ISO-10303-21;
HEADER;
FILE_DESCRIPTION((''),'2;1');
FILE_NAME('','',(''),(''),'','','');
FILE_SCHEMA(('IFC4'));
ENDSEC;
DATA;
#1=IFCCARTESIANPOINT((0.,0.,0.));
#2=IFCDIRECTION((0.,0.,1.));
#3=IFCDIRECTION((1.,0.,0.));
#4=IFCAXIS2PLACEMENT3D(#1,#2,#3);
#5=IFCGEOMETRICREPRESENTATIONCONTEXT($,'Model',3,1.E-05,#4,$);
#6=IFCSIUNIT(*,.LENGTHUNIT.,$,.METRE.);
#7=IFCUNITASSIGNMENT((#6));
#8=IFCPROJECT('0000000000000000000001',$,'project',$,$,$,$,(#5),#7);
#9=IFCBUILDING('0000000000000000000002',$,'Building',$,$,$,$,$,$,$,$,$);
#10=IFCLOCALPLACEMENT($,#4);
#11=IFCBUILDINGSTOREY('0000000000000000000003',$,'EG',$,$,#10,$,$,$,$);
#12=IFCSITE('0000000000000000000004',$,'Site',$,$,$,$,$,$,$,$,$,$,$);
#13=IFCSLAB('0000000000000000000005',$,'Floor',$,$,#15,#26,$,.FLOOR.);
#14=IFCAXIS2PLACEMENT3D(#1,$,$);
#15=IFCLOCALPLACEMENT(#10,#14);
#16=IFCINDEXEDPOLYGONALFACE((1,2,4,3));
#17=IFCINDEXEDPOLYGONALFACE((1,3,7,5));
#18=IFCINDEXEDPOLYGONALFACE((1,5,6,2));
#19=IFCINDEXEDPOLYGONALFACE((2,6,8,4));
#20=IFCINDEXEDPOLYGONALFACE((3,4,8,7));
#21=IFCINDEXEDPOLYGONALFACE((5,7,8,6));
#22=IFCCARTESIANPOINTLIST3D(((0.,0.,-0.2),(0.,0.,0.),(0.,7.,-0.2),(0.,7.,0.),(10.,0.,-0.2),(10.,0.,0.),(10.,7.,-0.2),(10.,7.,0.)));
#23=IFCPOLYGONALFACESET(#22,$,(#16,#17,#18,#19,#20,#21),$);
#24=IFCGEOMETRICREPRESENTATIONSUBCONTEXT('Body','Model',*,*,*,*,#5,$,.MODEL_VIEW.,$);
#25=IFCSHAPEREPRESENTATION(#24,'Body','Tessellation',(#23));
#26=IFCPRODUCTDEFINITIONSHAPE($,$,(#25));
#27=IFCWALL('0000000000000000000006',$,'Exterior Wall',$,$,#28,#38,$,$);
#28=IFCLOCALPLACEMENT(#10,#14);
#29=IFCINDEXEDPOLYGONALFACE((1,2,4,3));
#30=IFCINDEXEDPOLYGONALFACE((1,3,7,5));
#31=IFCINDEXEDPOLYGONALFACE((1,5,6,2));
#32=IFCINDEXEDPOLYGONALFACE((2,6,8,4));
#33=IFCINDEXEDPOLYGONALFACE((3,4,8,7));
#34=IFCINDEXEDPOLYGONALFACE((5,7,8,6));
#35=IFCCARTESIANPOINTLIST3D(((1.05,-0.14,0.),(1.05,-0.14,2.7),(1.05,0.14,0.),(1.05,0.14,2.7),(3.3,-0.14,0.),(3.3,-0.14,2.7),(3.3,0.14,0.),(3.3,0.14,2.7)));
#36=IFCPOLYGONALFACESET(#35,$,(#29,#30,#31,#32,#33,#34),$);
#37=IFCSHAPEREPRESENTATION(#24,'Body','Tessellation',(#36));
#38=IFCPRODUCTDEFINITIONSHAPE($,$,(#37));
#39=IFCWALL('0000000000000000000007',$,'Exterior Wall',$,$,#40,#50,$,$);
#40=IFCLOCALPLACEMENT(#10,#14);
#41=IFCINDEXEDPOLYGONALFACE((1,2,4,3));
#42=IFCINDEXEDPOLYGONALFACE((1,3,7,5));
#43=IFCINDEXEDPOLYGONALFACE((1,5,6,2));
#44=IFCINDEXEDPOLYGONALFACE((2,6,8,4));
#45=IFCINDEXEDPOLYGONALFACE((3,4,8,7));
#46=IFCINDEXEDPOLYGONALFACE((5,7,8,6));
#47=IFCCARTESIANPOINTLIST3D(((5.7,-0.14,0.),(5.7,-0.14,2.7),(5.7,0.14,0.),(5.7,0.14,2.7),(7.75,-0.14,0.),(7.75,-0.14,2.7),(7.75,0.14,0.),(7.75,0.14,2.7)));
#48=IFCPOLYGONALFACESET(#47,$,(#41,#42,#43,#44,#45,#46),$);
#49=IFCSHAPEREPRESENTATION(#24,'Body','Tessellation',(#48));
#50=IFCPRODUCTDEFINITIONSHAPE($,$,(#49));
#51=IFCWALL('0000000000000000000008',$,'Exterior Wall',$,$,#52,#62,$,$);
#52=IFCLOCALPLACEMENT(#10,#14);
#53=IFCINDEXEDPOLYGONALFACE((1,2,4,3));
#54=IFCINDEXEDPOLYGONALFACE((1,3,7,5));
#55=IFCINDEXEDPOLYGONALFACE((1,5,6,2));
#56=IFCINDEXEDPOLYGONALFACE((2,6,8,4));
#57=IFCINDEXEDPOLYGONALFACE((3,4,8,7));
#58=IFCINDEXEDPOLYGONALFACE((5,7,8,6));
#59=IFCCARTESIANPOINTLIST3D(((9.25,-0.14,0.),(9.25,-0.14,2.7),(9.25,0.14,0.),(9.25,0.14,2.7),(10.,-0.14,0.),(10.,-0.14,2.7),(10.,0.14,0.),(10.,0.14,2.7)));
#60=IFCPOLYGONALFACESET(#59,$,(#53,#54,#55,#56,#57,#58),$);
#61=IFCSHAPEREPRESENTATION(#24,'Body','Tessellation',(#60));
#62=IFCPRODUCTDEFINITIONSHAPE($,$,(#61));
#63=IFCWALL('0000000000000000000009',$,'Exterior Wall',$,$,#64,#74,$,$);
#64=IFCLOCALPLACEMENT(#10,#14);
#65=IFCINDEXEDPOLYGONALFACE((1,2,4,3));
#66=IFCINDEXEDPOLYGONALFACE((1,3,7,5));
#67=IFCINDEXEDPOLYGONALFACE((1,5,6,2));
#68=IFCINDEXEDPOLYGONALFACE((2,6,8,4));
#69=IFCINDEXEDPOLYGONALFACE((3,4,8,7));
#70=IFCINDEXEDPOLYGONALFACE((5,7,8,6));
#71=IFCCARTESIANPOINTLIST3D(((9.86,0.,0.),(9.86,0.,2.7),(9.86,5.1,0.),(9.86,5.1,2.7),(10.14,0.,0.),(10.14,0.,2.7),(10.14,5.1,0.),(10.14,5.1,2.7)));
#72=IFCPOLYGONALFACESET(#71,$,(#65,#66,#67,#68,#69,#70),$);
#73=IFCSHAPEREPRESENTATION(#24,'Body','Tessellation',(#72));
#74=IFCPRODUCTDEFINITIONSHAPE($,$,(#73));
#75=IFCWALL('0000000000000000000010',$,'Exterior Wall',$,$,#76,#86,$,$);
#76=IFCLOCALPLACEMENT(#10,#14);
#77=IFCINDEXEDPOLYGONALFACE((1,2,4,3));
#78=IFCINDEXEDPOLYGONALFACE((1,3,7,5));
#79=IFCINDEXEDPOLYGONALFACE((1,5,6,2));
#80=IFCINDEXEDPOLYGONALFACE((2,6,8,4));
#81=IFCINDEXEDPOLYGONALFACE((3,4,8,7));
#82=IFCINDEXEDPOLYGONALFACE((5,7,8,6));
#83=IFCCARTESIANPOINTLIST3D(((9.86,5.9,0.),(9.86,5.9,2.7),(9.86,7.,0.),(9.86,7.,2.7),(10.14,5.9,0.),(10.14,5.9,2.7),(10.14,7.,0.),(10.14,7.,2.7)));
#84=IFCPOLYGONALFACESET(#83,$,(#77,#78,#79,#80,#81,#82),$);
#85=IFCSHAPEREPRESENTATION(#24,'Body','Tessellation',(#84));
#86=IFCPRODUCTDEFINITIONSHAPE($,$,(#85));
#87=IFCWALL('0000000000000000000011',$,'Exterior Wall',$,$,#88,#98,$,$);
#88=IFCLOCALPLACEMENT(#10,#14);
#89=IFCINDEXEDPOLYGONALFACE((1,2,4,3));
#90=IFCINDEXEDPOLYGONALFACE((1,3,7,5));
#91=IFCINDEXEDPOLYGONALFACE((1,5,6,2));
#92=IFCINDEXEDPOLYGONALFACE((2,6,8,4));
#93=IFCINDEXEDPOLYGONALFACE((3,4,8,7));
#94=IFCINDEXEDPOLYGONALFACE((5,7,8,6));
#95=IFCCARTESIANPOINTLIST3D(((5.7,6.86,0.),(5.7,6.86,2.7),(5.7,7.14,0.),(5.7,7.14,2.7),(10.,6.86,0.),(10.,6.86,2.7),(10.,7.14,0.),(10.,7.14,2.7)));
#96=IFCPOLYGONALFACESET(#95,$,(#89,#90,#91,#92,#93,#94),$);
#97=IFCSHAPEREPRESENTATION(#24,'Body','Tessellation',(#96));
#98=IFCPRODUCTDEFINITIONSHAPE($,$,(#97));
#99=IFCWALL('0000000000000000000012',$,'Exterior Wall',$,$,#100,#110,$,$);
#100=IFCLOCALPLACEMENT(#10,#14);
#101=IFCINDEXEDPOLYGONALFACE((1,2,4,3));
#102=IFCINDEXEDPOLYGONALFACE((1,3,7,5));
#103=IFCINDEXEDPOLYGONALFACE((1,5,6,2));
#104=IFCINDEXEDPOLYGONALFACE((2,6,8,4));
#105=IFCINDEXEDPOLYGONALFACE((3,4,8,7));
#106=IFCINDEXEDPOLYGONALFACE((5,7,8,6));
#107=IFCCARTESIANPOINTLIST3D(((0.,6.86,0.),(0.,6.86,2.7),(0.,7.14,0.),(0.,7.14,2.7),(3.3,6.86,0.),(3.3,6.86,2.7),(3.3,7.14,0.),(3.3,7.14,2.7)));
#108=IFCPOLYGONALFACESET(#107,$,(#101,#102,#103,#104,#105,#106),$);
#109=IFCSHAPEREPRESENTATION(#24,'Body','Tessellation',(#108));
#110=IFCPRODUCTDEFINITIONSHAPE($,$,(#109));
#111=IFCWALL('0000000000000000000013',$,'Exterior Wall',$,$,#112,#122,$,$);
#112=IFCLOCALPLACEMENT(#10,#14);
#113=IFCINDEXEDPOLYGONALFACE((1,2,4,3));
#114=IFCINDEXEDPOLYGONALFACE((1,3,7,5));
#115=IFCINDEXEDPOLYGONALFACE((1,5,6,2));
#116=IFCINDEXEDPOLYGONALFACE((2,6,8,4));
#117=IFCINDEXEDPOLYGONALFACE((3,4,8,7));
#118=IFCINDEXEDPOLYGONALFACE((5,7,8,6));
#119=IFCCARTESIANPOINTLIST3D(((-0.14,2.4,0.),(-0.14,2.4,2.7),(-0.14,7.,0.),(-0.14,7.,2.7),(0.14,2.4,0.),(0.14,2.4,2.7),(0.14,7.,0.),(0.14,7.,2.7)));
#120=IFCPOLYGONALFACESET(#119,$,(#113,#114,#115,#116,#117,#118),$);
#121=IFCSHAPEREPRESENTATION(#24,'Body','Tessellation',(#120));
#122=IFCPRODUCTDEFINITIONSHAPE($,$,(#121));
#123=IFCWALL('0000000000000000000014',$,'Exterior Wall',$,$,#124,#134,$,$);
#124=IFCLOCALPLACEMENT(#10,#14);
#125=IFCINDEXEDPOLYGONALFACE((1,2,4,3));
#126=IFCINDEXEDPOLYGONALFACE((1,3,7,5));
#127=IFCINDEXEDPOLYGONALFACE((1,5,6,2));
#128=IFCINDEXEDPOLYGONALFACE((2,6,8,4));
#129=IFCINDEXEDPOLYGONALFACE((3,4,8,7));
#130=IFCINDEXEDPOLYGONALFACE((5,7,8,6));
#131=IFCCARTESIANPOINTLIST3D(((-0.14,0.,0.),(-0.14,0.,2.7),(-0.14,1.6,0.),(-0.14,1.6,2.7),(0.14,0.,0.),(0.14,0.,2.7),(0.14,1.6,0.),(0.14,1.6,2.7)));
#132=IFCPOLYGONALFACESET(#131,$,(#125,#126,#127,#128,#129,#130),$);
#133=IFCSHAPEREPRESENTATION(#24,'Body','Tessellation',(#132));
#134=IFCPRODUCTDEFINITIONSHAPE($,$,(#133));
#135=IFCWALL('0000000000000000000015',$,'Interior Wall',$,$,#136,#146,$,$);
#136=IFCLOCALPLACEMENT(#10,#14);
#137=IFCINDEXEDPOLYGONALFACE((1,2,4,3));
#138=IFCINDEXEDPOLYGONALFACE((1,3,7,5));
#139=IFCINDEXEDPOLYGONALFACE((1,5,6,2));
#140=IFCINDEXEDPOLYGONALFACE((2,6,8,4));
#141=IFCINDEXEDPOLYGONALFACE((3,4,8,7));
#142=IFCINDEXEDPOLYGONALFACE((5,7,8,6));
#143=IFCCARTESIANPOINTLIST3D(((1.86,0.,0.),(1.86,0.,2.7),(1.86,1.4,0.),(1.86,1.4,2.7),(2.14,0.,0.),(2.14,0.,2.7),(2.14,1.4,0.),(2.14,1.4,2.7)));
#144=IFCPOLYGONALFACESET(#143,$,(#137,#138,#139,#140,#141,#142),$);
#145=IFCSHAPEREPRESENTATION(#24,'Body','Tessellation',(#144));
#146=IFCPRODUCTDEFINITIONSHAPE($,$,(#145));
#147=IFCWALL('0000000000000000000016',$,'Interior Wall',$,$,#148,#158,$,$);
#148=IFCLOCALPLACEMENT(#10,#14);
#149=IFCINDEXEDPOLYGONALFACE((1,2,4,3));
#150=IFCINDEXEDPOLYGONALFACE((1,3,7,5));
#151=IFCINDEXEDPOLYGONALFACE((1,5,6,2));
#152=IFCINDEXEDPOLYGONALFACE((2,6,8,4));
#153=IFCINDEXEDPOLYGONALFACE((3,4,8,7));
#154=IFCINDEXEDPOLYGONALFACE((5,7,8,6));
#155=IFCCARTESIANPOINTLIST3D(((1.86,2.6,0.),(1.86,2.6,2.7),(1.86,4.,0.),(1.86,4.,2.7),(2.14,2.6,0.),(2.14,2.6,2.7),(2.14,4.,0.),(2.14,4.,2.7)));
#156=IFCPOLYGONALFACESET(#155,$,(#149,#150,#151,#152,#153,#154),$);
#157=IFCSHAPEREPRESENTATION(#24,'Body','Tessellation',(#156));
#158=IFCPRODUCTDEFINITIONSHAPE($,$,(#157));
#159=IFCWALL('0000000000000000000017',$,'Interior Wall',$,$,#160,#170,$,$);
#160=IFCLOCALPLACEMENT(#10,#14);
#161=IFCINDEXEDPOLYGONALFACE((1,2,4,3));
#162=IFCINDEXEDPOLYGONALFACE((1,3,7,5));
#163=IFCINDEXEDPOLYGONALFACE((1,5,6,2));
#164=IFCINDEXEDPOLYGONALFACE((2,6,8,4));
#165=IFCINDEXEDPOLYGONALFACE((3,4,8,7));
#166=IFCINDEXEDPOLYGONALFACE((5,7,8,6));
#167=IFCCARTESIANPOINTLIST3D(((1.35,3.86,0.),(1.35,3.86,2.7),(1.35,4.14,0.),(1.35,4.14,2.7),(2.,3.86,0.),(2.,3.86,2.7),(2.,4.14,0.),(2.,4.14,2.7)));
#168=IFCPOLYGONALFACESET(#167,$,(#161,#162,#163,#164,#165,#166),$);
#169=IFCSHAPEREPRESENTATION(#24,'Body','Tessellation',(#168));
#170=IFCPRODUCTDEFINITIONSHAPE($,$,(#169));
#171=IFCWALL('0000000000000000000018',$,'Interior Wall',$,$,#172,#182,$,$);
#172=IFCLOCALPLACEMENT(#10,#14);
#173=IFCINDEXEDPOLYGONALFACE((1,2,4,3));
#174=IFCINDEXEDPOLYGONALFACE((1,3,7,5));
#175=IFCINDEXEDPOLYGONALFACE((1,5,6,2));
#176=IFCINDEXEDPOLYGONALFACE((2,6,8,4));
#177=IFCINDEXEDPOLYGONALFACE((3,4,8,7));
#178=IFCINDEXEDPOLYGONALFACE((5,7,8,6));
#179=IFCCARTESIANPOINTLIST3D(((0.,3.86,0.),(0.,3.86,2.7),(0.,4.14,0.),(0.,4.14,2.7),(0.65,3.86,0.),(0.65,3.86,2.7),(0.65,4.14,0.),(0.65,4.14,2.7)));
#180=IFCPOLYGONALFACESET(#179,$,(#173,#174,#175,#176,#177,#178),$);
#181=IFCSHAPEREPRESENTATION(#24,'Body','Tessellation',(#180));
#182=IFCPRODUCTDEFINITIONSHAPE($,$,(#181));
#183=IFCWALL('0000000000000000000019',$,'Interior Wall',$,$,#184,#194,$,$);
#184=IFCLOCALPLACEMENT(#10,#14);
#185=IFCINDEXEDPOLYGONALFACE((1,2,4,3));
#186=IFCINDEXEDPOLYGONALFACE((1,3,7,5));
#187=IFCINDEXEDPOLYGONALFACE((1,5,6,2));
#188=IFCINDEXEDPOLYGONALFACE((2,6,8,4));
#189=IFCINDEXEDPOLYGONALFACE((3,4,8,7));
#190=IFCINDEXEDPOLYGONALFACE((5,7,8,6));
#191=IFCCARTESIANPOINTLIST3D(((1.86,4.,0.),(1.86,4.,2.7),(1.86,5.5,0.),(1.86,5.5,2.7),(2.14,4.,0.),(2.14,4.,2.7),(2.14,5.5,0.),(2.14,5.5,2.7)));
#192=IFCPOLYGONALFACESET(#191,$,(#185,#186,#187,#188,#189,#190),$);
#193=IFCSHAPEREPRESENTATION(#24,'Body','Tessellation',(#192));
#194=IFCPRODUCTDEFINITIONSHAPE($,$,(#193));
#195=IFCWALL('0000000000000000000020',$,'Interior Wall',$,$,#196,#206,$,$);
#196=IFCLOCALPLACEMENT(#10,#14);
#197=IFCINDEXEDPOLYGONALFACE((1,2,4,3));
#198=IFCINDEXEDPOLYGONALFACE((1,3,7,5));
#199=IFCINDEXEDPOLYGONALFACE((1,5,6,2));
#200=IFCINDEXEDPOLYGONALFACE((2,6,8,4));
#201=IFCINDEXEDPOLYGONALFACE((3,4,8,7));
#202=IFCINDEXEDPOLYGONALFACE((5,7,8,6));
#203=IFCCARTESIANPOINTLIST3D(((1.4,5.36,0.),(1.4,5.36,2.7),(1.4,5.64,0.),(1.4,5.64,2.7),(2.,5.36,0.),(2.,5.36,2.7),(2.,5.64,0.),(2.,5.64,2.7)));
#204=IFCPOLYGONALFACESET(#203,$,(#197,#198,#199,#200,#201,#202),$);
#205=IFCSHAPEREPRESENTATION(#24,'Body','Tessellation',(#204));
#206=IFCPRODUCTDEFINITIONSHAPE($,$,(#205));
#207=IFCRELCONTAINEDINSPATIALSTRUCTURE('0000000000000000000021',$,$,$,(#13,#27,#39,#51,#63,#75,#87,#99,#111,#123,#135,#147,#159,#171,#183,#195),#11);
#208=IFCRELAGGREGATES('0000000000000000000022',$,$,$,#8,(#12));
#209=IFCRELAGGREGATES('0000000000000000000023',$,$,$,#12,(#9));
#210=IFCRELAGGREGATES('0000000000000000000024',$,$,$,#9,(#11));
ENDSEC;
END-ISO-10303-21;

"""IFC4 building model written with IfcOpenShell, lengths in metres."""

from ifc_helpers import new_model, si_unit, frame, origin_with_axes, place, context, subcontext, project, spatial, indexed_curve, outline, extrude, element, save


model = new_model("IFC4")

# Units and contexts
model_context = context("Model", 3, precision=1e-05, world=origin_with_axes())
body_context = subcontext(model_context, "Body", "Model", "MODEL_VIEW")
ifc_project = project(units=[si_unit("LENGTHUNIT", "METRE")], contexts=[model_context])

# Site, building, storey
site = spatial("IfcSite", under=ifc_project, Name="Site")
building = spatial("IfcBuilding", under=site, Name="Building")
storey_placement = place(None, origin_with_axes())
storey = spatial("IfcBuildingStorey", under=building, at=storey_placement, Name="EG")

# Slab
slab_placement = place(storey_placement, frame((0.0, 0.0, -0.2), z_axis=(0.0, 0.0, 1.0), x_axis=(1.0, 0.0, 0.0)))
element("IfcSlab", 1, at=slab_placement, inside=storey, Name="Floor", PredefinedType="FLOOR", context=body_context, shape_type="SweptSolid", body=[
    extrude(outline(indexed_curve([(0.0, 0.0), (10.0, 0.0), (10.0, 7.0), (0.0, 7.0)])), None, (0.0, 0.0, 1.0), 0.2),
])

# Walls
wall_1_placement = place(storey_placement, frame((1.05, 0.0, 0.0), z_axis=(0.0, 0.0, 1.0), x_axis=(1.0, 0.0, 0.0)))
element("IfcWall", 2, at=wall_1_placement, inside=storey, Name="Exterior Wall", context=body_context, shape_type="SweptSolid", body=[
    extrude(outline(indexed_curve([(0.0, 0.0), (0.0, 0.28), (2.25, 0.28), (2.25, 0.0), (0.0, 0.0)], self_intersect=False)), frame((0.0, -0.14, 0.0), z_axis=(0.0, 0.0, 1.0), x_axis=(1.0, 0.0, 0.0)), (0.0, 0.0, 1.0), 2.7),
])
wall_2_placement = place(storey_placement, frame((5.7, 0.0, 0.0), z_axis=(0.0, 0.0, 1.0), x_axis=(1.0, 0.0, 0.0)))
element("IfcWall", 3, at=wall_2_placement, inside=storey, Name="Exterior Wall", context=body_context, shape_type="SweptSolid", body=[
    extrude(outline(indexed_curve([(0.0, 0.0), (0.0, 0.28), (2.05, 0.28), (2.05, 0.0), (0.0, 0.0)], self_intersect=False)), frame((0.0, -0.14, 0.0), z_axis=(0.0, 0.0, 1.0), x_axis=(1.0, 0.0, 0.0)), (0.0, 0.0, 1.0), 2.7),
])
wall_3_placement = place(storey_placement, frame((9.25, 0.0, 0.0), z_axis=(0.0, 0.0, 1.0), x_axis=(1.0, 0.0, 0.0)))
element("IfcWall", 4, at=wall_3_placement, inside=storey, Name="Exterior Wall", context=body_context, shape_type="SweptSolid", body=[
    extrude(outline(indexed_curve([(0.0, 0.0), (0.0, 0.28), (0.75, 0.28), (0.75, 0.0), (0.0, 0.0)], self_intersect=False)), frame((0.0, -0.14, 0.0), z_axis=(0.0, 0.0, 1.0), x_axis=(1.0, 0.0, 0.0)), (0.0, 0.0, 1.0), 2.7),
])
wall_4_placement = place(storey_placement, frame((10.0, 0.0, 0.0), z_axis=(0.0, 0.0, 1.0), x_axis=(0.0, 1.0, 0.0)))
element("IfcWall", 5, at=wall_4_placement, inside=storey, Name="Exterior Wall", context=body_context, shape_type="SweptSolid", body=[
    extrude(outline(indexed_curve([(0.0, 0.0), (0.0, 0.28), (5.1, 0.28), (5.1, 0.0), (0.0, 0.0)], self_intersect=False)), frame((0.0, -0.14, 0.0), z_axis=(0.0, 0.0, 1.0), x_axis=(1.0, 0.0, 0.0)), (0.0, 0.0, 1.0), 2.7),
])
wall_5_placement = place(storey_placement, frame((10.0, 5.9, 0.0), z_axis=(0.0, 0.0, 1.0), x_axis=(0.0, 1.0, 0.0)))
element("IfcWall", 6, at=wall_5_placement, inside=storey, Name="Exterior Wall", context=body_context, shape_type="SweptSolid", body=[
    extrude(outline(indexed_curve([(0.0, 0.0), (0.0, 0.28), (1.1, 0.28), (1.1, 0.0), (0.0, 0.0)], self_intersect=False)), frame((0.0, -0.14, 0.0), z_axis=(0.0, 0.0, 1.0), x_axis=(1.0, 0.0, 0.0)), (0.0, 0.0, 1.0), 2.7),
])
wall_6_placement = place(storey_placement, frame((10.0, 7.0, 0.0), z_axis=(0.0, 0.0, 1.0), x_axis=(-1.0, 0.0, 0.0)))
element("IfcWall", 7, at=wall_6_placement, inside=storey, Name="Exterior Wall", context=body_context, shape_type="SweptSolid", body=[
    extrude(outline(indexed_curve([(0.0, 0.0), (0.0, 0.28), (4.3, 0.28), (4.3, 0.0), (0.0, 0.0)], self_intersect=False)), frame((0.0, -0.14, 0.0), z_axis=(0.0, 0.0, 1.0), x_axis=(1.0, 0.0, 0.0)), (0.0, 0.0, 1.0), 2.7),
])
wall_7_placement = place(storey_placement, frame((3.3, 7.0, 0.0), z_axis=(0.0, 0.0, 1.0), x_axis=(-1.0, 0.0, 0.0)))
element("IfcWall", 8, at=wall_7_placement, inside=storey, Name="Exterior Wall", context=body_context, shape_type="SweptSolid", body=[
    extrude(outline(indexed_curve([(0.0, 0.0), (0.0, 0.28), (3.3, 0.28), (3.3, 0.0), (0.0, 0.0)], self_intersect=False)), frame((0.0, -0.14, 0.0), z_axis=(0.0, 0.0, 1.0), x_axis=(1.0, 0.0, 0.0)), (0.0, 0.0, 1.0), 2.7),
])
wall_8_placement = place(storey_placement, frame((0.0, 7.0, 0.0), z_axis=(0.0, 0.0, 1.0), x_axis=(0.0, -1.0, 0.0)))
element("IfcWall", 9, at=wall_8_placement, inside=storey, Name="Exterior Wall", context=body_context, shape_type="SweptSolid", body=[
    extrude(outline(indexed_curve([(0.0, 0.0), (0.0, 0.28), (4.6, 0.28), (4.6, 0.0), (0.0, 0.0)], self_intersect=False)), frame((0.0, -0.14, 0.0), z_axis=(0.0, 0.0, 1.0), x_axis=(1.0, 0.0, 0.0)), (0.0, 0.0, 1.0), 2.7),
])
wall_9_placement = place(storey_placement, frame((0.0, 1.6, 0.0), z_axis=(0.0, 0.0, 1.0), x_axis=(0.0, -1.0, 0.0)))
element("IfcWall", 10, at=wall_9_placement, inside=storey, Name="Exterior Wall", context=body_context, shape_type="SweptSolid", body=[
    extrude(outline(indexed_curve([(0.0, 0.0), (0.0, 0.28), (1.6, 0.28), (1.6, 0.0), (0.0, 0.0)], self_intersect=False)), frame((0.0, -0.14, 0.0), z_axis=(0.0, 0.0, 1.0), x_axis=(1.0, 0.0, 0.0)), (0.0, 0.0, 1.0), 2.7),
])
for number, where, z_axis, x_axis, name in (
    (11, (2.0, 0.0, 0.0), (0.0, 0.0, 1.0), (0.0, 1.0, 0.0), "Interior Wall"),
    (12, (2.0, 2.6, 0.0), (0.0, 0.0, 1.0), (0.0, 1.0, 0.0), "Interior Wall"),
):
    element("IfcWall", number, at=place(storey_placement, frame(where, z_axis=z_axis, x_axis=x_axis)), inside=storey, Name=name, context=body_context, shape_type="SweptSolid", body=[
        extrude(outline(indexed_curve([(0.0, 0.0), (0.0, 0.28), (1.4, 0.28), (1.4, 0.0), (0.0, 0.0)], self_intersect=False)), frame((0.0, -0.14, 0.0), z_axis=(0.0, 0.0, 1.0), x_axis=(1.0, 0.0, 0.0)), (0.0, 0.0, 1.0), 2.7),
    ])
for number, where, z_axis, x_axis, name in (
    (13, (2.0, 4.0, 0.0), (0.0, 0.0, 1.0), (-1.0, 0.0, 0.0), "Interior Wall"),
    (14, (0.65, 4.0, 0.0), (0.0, 0.0, 1.0), (-1.0, 0.0, 0.0), "Interior Wall"),
):
    element("IfcWall", number, at=place(storey_placement, frame(where, z_axis=z_axis, x_axis=x_axis)), inside=storey, Name=name, context=body_context, shape_type="SweptSolid", body=[
        extrude(outline(indexed_curve([(0.0, 0.0), (0.0, 0.28), (0.65, 0.28), (0.65, 0.0), (0.0, 0.0)], self_intersect=False)), frame((0.0, -0.14, 0.0), z_axis=(0.0, 0.0, 1.0), x_axis=(1.0, 0.0, 0.0)), (0.0, 0.0, 1.0), 2.7),
    ])
wall_10_placement = place(storey_placement, frame((2.0, 4.0, 0.0), z_axis=(0.0, 0.0, 1.0), x_axis=(0.0, 1.0, 0.0)))
element("IfcWall", 15, at=wall_10_placement, inside=storey, Name="Interior Wall", context=body_context, shape_type="SweptSolid", body=[
    extrude(outline(indexed_curve([(0.0, 0.0), (0.0, 0.28), (1.5, 0.28), (1.5, 0.0), (0.0, 0.0)], self_intersect=False)), frame((0.0, -0.14, 0.0), z_axis=(0.0, 0.0, 1.0), x_axis=(1.0, 0.0, 0.0)), (0.0, 0.0, 1.0), 2.7),
])
for number, where, z_axis, x_axis, name in (
    (16, (2.0, 5.5, 0.0), (0.0, 0.0, 1.0), (-1.0, 0.0, 0.0), "Interior Wall"),
):
    element("IfcWall", number, at=place(storey_placement, frame(where, z_axis=z_axis, x_axis=x_axis)), inside=storey, Name=name, context=body_context, shape_type="SweptSolid", body=[
        extrude(outline(indexed_curve([(0.0, 0.0), (0.0, 0.28), (0.6, 0.28), (0.6, 0.0), (0.0, 0.0)], self_intersect=False)), frame((0.0, -0.14, 0.0), z_axis=(0.0, 0.0, 1.0), x_axis=(1.0, 0.0, 0.0)), (0.0, 0.0, 1.0), 2.7),
    ])

save(model, "model.ifc")
